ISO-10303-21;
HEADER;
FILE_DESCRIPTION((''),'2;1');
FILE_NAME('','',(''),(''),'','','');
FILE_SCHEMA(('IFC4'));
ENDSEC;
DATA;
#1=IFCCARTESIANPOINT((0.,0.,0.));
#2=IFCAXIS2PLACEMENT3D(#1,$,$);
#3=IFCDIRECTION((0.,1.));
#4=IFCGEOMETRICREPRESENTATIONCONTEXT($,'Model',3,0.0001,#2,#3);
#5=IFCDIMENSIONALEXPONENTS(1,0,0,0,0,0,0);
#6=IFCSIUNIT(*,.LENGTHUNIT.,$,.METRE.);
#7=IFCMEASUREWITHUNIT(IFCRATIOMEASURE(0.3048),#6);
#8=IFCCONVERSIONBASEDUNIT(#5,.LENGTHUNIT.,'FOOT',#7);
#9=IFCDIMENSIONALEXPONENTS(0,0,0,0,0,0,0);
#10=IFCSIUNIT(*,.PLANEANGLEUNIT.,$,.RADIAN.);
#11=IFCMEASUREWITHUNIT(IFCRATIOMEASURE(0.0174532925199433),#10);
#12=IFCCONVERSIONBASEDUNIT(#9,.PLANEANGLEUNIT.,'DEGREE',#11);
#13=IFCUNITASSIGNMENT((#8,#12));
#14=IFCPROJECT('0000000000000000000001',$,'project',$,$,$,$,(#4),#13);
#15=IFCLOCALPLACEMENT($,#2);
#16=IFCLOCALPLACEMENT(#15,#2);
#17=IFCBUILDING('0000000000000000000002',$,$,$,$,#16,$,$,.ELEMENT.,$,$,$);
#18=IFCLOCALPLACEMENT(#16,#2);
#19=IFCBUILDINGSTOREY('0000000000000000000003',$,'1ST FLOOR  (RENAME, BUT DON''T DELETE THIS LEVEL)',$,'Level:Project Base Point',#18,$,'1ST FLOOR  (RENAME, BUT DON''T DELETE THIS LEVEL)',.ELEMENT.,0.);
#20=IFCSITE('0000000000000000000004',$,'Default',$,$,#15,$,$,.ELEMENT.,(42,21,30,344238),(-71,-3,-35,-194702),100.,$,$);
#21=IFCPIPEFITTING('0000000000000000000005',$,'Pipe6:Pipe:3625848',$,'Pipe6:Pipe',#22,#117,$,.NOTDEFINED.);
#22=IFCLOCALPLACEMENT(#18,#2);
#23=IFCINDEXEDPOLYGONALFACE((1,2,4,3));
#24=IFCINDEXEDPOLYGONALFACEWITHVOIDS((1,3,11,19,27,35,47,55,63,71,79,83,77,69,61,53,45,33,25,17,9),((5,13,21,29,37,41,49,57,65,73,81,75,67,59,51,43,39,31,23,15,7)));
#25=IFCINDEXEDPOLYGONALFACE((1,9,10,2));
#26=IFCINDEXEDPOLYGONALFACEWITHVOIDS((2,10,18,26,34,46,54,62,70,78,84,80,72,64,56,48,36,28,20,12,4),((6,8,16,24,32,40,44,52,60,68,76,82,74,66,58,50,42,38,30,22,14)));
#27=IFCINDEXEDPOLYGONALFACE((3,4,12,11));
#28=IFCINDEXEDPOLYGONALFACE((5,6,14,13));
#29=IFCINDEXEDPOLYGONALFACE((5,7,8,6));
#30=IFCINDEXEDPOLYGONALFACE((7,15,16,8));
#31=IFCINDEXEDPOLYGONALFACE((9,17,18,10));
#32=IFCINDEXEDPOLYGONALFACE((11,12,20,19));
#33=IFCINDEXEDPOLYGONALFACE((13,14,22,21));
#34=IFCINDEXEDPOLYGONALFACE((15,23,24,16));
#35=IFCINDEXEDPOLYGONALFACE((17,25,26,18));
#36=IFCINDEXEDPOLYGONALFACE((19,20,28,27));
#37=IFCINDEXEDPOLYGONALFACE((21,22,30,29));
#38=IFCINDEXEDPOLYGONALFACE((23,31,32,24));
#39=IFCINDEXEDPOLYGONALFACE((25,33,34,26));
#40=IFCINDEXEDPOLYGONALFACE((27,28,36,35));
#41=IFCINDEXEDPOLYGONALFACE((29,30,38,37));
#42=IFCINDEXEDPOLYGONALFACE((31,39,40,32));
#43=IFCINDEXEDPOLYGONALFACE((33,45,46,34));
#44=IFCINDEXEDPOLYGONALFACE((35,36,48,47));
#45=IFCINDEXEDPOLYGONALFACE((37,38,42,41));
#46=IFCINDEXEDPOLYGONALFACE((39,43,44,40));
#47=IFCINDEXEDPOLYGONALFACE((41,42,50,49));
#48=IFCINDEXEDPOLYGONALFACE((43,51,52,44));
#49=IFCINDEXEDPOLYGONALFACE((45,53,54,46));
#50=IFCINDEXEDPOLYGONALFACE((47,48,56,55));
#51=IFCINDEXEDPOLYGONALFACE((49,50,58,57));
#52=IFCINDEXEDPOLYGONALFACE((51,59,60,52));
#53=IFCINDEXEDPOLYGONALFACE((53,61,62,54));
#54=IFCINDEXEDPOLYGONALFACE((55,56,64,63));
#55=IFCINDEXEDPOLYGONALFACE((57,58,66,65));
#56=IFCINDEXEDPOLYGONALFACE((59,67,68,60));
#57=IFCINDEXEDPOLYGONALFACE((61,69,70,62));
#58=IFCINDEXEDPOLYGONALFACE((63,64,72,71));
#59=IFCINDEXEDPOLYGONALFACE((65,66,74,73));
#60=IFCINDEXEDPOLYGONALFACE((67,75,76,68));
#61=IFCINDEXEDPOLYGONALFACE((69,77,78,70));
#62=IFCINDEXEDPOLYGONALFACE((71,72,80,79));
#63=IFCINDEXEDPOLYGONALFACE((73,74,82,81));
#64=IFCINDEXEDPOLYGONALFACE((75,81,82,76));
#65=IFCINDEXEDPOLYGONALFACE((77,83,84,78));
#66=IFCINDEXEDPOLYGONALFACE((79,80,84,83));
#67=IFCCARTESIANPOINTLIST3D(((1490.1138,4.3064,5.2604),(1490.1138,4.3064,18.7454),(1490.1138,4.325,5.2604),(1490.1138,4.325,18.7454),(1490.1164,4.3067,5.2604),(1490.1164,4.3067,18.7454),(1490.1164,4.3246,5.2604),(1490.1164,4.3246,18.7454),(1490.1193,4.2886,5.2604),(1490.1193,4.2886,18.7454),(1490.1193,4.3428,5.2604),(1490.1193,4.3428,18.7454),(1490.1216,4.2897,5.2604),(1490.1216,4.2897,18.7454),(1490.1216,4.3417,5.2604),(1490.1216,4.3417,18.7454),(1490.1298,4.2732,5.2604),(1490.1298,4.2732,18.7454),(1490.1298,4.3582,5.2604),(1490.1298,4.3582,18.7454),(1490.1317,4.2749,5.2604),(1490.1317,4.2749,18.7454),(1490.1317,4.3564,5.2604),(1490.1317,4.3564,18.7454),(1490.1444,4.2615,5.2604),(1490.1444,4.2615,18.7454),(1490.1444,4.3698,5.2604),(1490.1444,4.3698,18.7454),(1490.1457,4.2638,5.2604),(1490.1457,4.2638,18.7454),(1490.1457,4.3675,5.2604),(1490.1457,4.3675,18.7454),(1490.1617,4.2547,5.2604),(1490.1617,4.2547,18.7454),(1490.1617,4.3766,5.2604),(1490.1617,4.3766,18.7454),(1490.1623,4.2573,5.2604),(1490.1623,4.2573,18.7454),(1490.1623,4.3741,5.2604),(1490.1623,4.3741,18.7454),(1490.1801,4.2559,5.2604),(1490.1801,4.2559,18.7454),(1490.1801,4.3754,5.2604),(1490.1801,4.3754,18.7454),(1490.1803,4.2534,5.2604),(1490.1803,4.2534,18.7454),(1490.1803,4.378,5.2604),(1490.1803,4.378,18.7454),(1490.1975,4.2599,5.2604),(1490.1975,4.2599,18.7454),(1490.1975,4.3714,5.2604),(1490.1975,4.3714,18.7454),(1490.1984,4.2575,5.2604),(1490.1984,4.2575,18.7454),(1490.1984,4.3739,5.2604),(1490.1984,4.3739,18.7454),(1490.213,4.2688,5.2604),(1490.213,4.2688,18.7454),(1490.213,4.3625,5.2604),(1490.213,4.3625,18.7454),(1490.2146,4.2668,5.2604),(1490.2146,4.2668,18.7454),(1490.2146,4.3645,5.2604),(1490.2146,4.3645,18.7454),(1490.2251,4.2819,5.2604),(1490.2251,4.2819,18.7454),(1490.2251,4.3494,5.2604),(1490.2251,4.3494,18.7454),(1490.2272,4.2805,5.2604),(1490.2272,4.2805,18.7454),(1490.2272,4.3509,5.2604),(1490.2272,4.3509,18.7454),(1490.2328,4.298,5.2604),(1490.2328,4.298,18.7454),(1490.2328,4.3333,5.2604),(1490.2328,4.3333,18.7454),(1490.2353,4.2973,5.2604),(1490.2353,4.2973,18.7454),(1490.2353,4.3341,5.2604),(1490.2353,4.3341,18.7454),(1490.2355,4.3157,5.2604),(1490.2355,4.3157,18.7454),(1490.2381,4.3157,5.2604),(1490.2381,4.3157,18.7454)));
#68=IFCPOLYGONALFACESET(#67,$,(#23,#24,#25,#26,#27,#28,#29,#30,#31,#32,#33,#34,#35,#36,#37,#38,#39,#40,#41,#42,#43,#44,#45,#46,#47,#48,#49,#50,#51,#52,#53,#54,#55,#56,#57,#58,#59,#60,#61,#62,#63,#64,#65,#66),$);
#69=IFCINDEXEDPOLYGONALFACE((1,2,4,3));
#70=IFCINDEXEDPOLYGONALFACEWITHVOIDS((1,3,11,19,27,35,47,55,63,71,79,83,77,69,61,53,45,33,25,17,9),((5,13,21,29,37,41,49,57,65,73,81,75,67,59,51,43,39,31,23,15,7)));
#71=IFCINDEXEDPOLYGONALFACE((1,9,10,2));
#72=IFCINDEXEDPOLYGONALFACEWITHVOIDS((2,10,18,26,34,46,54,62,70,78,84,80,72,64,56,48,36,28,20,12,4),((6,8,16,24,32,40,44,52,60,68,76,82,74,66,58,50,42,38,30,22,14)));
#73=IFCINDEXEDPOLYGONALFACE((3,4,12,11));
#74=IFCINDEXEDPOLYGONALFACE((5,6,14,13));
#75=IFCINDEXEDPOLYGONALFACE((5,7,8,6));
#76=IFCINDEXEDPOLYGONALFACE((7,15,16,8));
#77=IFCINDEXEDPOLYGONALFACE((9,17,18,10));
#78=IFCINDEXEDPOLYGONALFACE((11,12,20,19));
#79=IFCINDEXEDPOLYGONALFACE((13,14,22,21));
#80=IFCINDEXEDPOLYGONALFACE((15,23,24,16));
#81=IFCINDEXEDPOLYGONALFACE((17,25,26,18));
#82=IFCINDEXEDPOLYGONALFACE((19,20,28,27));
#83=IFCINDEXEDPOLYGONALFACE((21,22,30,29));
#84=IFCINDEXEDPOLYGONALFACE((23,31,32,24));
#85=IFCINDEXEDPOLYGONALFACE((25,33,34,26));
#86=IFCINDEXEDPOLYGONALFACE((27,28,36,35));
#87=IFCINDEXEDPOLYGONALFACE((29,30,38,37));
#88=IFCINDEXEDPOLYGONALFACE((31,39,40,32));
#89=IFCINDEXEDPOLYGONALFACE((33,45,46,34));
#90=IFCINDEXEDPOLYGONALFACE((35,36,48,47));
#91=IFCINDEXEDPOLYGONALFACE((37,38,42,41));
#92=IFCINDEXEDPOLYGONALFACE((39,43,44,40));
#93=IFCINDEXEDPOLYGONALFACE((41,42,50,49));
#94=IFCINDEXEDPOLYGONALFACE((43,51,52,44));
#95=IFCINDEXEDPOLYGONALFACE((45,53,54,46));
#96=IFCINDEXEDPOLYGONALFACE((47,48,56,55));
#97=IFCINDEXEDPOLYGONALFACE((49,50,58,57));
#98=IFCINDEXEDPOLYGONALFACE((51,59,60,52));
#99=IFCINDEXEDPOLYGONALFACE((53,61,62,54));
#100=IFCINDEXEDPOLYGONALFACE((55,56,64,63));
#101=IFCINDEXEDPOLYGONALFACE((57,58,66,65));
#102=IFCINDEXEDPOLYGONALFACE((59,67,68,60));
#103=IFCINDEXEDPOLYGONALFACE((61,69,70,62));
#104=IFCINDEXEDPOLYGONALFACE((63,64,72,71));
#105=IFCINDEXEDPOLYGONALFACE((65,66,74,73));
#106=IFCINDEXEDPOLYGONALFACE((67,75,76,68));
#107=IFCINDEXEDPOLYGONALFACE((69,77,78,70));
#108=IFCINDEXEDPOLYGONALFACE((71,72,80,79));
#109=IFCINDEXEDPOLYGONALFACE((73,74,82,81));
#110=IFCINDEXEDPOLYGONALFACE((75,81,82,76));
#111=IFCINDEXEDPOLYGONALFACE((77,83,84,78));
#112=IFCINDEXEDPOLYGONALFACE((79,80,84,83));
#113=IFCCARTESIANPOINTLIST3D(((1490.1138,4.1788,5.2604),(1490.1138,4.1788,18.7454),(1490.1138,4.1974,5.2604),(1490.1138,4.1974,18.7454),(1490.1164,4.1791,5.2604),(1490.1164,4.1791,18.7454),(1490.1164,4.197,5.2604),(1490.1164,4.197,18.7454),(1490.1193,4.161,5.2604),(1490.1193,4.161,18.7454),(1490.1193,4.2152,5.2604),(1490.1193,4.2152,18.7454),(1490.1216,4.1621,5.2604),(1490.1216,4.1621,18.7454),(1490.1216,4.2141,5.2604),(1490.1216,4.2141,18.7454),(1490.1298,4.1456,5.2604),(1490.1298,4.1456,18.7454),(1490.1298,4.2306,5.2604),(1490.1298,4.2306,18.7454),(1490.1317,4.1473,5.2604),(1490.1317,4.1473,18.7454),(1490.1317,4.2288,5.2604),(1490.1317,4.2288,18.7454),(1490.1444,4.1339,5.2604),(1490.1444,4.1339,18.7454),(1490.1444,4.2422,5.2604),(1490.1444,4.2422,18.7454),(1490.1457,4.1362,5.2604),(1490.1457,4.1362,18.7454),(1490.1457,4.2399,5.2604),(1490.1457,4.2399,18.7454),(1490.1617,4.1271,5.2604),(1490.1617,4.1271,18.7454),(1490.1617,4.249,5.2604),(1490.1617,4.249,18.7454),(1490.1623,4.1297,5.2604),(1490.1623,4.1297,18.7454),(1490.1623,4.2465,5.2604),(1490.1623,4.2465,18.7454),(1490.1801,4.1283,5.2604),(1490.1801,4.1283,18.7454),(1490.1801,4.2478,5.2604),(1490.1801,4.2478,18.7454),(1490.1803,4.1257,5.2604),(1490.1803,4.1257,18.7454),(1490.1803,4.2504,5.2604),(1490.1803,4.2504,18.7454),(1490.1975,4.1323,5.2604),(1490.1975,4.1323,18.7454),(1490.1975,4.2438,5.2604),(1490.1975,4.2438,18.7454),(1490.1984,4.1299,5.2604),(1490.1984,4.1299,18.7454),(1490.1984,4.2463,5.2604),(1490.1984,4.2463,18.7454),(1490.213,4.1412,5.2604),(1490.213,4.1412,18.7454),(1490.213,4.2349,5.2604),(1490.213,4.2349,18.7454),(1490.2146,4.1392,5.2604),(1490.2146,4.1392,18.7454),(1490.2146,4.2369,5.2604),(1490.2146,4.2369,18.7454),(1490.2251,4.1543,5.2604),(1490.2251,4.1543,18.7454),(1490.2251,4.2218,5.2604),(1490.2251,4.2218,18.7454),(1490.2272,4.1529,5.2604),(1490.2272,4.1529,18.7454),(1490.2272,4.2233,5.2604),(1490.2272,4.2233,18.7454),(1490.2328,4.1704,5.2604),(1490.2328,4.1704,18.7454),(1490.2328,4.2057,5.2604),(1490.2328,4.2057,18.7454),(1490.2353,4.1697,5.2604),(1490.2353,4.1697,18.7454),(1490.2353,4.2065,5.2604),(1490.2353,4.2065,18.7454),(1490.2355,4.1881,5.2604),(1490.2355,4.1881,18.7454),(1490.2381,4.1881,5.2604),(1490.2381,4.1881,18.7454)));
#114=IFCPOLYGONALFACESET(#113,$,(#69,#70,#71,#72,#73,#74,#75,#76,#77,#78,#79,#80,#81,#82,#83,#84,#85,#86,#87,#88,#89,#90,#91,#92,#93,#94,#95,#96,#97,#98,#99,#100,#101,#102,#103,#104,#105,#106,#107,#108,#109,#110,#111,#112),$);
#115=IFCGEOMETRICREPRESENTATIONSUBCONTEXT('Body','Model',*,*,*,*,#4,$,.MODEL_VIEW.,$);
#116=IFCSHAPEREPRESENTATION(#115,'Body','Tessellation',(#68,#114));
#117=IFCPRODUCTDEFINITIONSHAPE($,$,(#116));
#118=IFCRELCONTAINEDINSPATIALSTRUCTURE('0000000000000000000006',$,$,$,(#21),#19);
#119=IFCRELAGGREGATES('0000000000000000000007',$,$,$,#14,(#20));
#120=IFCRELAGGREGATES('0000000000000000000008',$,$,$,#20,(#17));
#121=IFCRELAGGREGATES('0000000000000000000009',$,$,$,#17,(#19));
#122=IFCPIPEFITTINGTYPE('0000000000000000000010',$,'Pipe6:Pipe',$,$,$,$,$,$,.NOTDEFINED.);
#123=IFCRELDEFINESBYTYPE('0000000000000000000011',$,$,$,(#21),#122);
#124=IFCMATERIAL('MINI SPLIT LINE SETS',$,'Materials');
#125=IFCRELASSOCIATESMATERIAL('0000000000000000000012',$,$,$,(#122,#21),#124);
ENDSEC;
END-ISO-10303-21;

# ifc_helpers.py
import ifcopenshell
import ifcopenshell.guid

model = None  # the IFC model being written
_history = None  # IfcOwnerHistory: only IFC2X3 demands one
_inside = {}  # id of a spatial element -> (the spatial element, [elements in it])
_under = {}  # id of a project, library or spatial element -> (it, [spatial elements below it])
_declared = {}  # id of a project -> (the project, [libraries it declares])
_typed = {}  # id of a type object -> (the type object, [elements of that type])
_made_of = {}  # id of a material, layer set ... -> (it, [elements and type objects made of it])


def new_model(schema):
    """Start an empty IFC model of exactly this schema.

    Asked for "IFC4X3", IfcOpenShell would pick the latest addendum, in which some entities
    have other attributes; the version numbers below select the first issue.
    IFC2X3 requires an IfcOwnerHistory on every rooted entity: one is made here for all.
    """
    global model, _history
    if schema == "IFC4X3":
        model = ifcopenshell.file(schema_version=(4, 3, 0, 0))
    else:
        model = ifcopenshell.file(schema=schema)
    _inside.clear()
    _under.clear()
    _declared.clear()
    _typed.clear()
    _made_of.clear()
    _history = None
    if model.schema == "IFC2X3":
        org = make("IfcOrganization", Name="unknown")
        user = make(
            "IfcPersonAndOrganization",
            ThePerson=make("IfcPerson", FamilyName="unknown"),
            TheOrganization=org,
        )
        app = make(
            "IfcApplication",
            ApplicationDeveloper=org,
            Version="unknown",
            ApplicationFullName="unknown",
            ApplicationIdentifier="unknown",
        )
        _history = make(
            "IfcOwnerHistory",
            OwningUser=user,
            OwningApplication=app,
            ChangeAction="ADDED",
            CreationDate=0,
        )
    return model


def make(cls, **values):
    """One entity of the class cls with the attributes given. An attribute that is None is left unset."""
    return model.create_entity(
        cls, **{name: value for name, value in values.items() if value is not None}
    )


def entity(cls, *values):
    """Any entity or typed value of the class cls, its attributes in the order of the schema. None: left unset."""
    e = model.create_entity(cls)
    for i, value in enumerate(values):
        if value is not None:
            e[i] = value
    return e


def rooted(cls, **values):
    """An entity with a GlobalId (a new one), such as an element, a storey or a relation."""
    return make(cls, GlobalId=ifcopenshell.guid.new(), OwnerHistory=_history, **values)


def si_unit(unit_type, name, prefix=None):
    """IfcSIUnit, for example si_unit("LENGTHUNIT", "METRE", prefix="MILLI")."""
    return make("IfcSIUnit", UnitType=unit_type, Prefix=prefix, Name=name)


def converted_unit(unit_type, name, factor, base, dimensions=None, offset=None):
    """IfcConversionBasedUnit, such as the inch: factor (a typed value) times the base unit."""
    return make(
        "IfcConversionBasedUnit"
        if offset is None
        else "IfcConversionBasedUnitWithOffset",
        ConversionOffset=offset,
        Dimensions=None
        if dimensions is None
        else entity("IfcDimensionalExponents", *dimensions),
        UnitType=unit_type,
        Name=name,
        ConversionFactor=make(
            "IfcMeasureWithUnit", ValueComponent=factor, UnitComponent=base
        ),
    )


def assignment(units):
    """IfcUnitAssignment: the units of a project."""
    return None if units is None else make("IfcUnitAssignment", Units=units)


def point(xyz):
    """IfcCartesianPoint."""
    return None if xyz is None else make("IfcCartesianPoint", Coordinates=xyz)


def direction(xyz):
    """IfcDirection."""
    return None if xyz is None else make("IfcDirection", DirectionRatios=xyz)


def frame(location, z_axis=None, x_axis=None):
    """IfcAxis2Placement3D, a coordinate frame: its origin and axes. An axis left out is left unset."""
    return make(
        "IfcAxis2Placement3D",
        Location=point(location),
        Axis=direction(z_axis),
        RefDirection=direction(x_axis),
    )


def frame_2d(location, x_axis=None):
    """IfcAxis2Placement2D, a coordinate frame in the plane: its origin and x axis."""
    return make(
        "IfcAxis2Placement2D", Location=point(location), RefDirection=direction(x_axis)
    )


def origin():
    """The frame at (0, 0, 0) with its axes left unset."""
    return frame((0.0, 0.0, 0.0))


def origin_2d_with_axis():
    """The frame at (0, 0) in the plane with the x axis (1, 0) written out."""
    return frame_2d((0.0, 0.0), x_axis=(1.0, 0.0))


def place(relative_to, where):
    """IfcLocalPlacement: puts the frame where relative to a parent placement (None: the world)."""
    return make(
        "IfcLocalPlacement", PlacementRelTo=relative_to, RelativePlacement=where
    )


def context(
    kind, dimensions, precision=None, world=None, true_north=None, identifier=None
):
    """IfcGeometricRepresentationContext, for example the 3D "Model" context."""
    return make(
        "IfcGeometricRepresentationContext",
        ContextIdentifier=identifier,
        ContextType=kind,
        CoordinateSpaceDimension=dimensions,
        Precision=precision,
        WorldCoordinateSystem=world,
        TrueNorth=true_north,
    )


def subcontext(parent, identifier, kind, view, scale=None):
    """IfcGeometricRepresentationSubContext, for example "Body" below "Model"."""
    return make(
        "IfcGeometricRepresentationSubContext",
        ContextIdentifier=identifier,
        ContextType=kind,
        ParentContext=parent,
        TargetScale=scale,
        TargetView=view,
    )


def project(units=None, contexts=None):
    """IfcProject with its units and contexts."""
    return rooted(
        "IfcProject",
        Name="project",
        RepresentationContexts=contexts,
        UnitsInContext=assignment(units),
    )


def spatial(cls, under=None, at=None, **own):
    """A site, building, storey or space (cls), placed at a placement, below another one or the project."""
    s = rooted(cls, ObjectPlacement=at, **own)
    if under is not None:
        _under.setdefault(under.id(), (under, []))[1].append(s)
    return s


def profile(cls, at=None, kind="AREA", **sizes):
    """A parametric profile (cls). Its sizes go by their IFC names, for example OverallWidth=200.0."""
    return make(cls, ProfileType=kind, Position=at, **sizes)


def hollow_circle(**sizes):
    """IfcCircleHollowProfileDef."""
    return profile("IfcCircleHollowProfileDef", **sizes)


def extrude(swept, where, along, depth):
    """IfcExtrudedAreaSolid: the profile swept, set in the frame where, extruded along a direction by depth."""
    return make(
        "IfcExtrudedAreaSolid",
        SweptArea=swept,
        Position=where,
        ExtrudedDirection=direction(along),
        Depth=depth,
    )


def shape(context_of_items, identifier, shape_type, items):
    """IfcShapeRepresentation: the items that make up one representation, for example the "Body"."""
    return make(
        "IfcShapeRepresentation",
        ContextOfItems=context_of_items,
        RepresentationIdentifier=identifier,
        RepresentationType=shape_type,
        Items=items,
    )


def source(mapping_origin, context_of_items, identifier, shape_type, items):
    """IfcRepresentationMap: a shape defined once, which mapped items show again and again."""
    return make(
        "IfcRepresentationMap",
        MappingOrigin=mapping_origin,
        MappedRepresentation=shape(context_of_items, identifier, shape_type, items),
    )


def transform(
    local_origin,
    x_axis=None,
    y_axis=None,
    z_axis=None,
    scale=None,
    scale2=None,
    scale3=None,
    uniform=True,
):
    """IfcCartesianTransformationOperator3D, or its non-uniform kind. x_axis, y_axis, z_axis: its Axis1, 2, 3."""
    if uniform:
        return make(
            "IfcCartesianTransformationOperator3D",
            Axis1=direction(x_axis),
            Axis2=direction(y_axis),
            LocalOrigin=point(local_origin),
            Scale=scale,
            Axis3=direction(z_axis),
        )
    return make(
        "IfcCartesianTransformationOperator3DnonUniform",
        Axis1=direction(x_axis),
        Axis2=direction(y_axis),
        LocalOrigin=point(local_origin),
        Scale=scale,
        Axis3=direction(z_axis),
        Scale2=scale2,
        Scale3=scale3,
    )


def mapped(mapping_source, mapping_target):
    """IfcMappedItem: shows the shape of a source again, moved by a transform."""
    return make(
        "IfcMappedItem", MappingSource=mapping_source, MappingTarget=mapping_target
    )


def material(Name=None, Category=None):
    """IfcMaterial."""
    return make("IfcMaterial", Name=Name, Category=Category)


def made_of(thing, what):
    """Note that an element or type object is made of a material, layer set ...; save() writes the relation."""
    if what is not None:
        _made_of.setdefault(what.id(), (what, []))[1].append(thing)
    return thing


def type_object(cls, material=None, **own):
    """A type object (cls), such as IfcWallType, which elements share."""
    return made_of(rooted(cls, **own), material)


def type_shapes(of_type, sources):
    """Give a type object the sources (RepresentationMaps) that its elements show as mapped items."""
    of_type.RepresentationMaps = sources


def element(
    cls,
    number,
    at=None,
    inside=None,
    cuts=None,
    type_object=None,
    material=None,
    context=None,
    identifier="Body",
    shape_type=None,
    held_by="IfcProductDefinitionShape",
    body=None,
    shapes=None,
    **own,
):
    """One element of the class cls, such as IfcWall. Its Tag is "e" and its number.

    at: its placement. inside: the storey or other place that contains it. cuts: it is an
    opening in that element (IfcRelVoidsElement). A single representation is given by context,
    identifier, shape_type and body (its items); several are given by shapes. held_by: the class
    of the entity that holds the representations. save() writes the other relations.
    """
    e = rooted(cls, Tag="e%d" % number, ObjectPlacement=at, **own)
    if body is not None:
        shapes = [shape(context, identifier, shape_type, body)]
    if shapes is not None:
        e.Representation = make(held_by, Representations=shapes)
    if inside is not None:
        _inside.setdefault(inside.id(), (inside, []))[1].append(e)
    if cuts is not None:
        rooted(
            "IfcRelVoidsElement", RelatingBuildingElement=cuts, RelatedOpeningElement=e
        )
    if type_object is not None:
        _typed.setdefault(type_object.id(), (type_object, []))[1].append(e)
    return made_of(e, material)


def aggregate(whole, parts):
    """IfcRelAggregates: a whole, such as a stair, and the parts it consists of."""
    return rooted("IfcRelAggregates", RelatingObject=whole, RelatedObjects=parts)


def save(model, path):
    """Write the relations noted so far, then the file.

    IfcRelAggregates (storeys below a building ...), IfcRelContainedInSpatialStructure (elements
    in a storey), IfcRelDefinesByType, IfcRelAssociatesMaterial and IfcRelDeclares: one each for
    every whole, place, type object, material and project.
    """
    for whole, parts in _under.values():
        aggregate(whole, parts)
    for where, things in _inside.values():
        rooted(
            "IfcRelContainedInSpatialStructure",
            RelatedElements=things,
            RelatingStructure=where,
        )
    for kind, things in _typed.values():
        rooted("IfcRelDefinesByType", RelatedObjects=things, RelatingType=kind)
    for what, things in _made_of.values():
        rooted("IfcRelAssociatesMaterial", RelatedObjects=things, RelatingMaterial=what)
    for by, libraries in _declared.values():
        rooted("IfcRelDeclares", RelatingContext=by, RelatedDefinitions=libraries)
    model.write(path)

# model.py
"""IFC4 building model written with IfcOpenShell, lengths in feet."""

from ifc_helpers import new_model, entity, si_unit, converted_unit, direction, frame, origin, origin_2d_with_axis, place, context, subcontext, project, spatial, hollow_circle, extrude, source, transform, mapped, material, type_object, type_shapes, element, save


model = new_model("IFC4")

# Units and contexts
model_context = context("Model", 3, precision=0.0001, world=origin(), true_north=direction((0.0, 1.0)))
body_context = subcontext(model_context, "Body", "Model", "MODEL_VIEW")
ifc_project = project(units=[converted_unit("LENGTHUNIT", "FOOT", entity("IfcRatioMeasure", 0.3048), si_unit("LENGTHUNIT", "METRE"), dimensions=[1, 0, 0, 0, 0, 0, 0]), converted_unit("PLANEANGLEUNIT", "DEGREE", entity("IfcRatioMeasure", 0.0174532925199433), si_unit("PLANEANGLEUNIT", "RADIAN"), dimensions=[0, 0, 0, 0, 0, 0, 0])], contexts=[model_context])

# Site, building, storey
site_placement = place(None, origin())
site = spatial("IfcSite", under=ifc_project, at=site_placement, Name="Default", CompositionType="ELEMENT", RefLatitude=(42, 21, 30, 344238), RefLongitude=(-71, -3, -35, -194702), RefElevation=100.0)
building_placement = place(site_placement, origin())
building = spatial("IfcBuilding", under=site, at=building_placement, CompositionType="ELEMENT")
storey_placement = place(building_placement, origin())
storey = spatial("IfcBuildingStorey", under=building, at=storey_placement, Name="1ST FLOOR  (RENAME, BUT DON'T DELETE THIS LEVEL)", ObjectType="Level:Project Base Point", LongName="1ST FLOOR  (RENAME, BUT DON'T DELETE THIS LEVEL)", CompositionType="ELEMENT", Elevation=0.0)

# Shared definitions
ifc_material_1 = material(Name="MINI SPLIT LINE SETS", Category="Materials")

# Pipe fitting
pipe_fitting_type_1 = type_object("IfcPipeFittingType", Name="Pipe6:Pipe", PredefinedType="NOTDEFINED", material=ifc_material_1)
shared_shape_1 = source(origin(), body_context, "Body", "SweptSolid", [
    extrude(hollow_circle(Radius=0.0625, WallThickness=0.0026, at=origin_2d_with_axis()), frame((0.0677, 0.1953, 0.0)), (0.0, 0.0, 1.0), 13.485),
    extrude(hollow_circle(Radius=0.0625, WallThickness=0.0026, at=origin_2d_with_axis()), frame((0.0677, 0.0677, 0.0)), (0.0, 0.0, 1.0), 13.485),
])
type_shapes(pipe_fitting_type_1, [shared_shape_1])
pipe_fitting_1_placement = place(storey_placement, frame((1490.1079, 4.1203, 5.2604)))
element("IfcPipeFitting", 1, at=pipe_fitting_1_placement, inside=storey, type_object=pipe_fitting_type_1, material=ifc_material_1, Name="Pipe6:Pipe:3625848", ObjectType="Pipe6:Pipe", PredefinedType="NOTDEFINED", context=body_context, shape_type="MappedRepresentation", body=[
    mapped(shared_shape_1, transform((0.0, 0.0, 0.0), scale=1.0)),
])

save(model, "model.ifc")
